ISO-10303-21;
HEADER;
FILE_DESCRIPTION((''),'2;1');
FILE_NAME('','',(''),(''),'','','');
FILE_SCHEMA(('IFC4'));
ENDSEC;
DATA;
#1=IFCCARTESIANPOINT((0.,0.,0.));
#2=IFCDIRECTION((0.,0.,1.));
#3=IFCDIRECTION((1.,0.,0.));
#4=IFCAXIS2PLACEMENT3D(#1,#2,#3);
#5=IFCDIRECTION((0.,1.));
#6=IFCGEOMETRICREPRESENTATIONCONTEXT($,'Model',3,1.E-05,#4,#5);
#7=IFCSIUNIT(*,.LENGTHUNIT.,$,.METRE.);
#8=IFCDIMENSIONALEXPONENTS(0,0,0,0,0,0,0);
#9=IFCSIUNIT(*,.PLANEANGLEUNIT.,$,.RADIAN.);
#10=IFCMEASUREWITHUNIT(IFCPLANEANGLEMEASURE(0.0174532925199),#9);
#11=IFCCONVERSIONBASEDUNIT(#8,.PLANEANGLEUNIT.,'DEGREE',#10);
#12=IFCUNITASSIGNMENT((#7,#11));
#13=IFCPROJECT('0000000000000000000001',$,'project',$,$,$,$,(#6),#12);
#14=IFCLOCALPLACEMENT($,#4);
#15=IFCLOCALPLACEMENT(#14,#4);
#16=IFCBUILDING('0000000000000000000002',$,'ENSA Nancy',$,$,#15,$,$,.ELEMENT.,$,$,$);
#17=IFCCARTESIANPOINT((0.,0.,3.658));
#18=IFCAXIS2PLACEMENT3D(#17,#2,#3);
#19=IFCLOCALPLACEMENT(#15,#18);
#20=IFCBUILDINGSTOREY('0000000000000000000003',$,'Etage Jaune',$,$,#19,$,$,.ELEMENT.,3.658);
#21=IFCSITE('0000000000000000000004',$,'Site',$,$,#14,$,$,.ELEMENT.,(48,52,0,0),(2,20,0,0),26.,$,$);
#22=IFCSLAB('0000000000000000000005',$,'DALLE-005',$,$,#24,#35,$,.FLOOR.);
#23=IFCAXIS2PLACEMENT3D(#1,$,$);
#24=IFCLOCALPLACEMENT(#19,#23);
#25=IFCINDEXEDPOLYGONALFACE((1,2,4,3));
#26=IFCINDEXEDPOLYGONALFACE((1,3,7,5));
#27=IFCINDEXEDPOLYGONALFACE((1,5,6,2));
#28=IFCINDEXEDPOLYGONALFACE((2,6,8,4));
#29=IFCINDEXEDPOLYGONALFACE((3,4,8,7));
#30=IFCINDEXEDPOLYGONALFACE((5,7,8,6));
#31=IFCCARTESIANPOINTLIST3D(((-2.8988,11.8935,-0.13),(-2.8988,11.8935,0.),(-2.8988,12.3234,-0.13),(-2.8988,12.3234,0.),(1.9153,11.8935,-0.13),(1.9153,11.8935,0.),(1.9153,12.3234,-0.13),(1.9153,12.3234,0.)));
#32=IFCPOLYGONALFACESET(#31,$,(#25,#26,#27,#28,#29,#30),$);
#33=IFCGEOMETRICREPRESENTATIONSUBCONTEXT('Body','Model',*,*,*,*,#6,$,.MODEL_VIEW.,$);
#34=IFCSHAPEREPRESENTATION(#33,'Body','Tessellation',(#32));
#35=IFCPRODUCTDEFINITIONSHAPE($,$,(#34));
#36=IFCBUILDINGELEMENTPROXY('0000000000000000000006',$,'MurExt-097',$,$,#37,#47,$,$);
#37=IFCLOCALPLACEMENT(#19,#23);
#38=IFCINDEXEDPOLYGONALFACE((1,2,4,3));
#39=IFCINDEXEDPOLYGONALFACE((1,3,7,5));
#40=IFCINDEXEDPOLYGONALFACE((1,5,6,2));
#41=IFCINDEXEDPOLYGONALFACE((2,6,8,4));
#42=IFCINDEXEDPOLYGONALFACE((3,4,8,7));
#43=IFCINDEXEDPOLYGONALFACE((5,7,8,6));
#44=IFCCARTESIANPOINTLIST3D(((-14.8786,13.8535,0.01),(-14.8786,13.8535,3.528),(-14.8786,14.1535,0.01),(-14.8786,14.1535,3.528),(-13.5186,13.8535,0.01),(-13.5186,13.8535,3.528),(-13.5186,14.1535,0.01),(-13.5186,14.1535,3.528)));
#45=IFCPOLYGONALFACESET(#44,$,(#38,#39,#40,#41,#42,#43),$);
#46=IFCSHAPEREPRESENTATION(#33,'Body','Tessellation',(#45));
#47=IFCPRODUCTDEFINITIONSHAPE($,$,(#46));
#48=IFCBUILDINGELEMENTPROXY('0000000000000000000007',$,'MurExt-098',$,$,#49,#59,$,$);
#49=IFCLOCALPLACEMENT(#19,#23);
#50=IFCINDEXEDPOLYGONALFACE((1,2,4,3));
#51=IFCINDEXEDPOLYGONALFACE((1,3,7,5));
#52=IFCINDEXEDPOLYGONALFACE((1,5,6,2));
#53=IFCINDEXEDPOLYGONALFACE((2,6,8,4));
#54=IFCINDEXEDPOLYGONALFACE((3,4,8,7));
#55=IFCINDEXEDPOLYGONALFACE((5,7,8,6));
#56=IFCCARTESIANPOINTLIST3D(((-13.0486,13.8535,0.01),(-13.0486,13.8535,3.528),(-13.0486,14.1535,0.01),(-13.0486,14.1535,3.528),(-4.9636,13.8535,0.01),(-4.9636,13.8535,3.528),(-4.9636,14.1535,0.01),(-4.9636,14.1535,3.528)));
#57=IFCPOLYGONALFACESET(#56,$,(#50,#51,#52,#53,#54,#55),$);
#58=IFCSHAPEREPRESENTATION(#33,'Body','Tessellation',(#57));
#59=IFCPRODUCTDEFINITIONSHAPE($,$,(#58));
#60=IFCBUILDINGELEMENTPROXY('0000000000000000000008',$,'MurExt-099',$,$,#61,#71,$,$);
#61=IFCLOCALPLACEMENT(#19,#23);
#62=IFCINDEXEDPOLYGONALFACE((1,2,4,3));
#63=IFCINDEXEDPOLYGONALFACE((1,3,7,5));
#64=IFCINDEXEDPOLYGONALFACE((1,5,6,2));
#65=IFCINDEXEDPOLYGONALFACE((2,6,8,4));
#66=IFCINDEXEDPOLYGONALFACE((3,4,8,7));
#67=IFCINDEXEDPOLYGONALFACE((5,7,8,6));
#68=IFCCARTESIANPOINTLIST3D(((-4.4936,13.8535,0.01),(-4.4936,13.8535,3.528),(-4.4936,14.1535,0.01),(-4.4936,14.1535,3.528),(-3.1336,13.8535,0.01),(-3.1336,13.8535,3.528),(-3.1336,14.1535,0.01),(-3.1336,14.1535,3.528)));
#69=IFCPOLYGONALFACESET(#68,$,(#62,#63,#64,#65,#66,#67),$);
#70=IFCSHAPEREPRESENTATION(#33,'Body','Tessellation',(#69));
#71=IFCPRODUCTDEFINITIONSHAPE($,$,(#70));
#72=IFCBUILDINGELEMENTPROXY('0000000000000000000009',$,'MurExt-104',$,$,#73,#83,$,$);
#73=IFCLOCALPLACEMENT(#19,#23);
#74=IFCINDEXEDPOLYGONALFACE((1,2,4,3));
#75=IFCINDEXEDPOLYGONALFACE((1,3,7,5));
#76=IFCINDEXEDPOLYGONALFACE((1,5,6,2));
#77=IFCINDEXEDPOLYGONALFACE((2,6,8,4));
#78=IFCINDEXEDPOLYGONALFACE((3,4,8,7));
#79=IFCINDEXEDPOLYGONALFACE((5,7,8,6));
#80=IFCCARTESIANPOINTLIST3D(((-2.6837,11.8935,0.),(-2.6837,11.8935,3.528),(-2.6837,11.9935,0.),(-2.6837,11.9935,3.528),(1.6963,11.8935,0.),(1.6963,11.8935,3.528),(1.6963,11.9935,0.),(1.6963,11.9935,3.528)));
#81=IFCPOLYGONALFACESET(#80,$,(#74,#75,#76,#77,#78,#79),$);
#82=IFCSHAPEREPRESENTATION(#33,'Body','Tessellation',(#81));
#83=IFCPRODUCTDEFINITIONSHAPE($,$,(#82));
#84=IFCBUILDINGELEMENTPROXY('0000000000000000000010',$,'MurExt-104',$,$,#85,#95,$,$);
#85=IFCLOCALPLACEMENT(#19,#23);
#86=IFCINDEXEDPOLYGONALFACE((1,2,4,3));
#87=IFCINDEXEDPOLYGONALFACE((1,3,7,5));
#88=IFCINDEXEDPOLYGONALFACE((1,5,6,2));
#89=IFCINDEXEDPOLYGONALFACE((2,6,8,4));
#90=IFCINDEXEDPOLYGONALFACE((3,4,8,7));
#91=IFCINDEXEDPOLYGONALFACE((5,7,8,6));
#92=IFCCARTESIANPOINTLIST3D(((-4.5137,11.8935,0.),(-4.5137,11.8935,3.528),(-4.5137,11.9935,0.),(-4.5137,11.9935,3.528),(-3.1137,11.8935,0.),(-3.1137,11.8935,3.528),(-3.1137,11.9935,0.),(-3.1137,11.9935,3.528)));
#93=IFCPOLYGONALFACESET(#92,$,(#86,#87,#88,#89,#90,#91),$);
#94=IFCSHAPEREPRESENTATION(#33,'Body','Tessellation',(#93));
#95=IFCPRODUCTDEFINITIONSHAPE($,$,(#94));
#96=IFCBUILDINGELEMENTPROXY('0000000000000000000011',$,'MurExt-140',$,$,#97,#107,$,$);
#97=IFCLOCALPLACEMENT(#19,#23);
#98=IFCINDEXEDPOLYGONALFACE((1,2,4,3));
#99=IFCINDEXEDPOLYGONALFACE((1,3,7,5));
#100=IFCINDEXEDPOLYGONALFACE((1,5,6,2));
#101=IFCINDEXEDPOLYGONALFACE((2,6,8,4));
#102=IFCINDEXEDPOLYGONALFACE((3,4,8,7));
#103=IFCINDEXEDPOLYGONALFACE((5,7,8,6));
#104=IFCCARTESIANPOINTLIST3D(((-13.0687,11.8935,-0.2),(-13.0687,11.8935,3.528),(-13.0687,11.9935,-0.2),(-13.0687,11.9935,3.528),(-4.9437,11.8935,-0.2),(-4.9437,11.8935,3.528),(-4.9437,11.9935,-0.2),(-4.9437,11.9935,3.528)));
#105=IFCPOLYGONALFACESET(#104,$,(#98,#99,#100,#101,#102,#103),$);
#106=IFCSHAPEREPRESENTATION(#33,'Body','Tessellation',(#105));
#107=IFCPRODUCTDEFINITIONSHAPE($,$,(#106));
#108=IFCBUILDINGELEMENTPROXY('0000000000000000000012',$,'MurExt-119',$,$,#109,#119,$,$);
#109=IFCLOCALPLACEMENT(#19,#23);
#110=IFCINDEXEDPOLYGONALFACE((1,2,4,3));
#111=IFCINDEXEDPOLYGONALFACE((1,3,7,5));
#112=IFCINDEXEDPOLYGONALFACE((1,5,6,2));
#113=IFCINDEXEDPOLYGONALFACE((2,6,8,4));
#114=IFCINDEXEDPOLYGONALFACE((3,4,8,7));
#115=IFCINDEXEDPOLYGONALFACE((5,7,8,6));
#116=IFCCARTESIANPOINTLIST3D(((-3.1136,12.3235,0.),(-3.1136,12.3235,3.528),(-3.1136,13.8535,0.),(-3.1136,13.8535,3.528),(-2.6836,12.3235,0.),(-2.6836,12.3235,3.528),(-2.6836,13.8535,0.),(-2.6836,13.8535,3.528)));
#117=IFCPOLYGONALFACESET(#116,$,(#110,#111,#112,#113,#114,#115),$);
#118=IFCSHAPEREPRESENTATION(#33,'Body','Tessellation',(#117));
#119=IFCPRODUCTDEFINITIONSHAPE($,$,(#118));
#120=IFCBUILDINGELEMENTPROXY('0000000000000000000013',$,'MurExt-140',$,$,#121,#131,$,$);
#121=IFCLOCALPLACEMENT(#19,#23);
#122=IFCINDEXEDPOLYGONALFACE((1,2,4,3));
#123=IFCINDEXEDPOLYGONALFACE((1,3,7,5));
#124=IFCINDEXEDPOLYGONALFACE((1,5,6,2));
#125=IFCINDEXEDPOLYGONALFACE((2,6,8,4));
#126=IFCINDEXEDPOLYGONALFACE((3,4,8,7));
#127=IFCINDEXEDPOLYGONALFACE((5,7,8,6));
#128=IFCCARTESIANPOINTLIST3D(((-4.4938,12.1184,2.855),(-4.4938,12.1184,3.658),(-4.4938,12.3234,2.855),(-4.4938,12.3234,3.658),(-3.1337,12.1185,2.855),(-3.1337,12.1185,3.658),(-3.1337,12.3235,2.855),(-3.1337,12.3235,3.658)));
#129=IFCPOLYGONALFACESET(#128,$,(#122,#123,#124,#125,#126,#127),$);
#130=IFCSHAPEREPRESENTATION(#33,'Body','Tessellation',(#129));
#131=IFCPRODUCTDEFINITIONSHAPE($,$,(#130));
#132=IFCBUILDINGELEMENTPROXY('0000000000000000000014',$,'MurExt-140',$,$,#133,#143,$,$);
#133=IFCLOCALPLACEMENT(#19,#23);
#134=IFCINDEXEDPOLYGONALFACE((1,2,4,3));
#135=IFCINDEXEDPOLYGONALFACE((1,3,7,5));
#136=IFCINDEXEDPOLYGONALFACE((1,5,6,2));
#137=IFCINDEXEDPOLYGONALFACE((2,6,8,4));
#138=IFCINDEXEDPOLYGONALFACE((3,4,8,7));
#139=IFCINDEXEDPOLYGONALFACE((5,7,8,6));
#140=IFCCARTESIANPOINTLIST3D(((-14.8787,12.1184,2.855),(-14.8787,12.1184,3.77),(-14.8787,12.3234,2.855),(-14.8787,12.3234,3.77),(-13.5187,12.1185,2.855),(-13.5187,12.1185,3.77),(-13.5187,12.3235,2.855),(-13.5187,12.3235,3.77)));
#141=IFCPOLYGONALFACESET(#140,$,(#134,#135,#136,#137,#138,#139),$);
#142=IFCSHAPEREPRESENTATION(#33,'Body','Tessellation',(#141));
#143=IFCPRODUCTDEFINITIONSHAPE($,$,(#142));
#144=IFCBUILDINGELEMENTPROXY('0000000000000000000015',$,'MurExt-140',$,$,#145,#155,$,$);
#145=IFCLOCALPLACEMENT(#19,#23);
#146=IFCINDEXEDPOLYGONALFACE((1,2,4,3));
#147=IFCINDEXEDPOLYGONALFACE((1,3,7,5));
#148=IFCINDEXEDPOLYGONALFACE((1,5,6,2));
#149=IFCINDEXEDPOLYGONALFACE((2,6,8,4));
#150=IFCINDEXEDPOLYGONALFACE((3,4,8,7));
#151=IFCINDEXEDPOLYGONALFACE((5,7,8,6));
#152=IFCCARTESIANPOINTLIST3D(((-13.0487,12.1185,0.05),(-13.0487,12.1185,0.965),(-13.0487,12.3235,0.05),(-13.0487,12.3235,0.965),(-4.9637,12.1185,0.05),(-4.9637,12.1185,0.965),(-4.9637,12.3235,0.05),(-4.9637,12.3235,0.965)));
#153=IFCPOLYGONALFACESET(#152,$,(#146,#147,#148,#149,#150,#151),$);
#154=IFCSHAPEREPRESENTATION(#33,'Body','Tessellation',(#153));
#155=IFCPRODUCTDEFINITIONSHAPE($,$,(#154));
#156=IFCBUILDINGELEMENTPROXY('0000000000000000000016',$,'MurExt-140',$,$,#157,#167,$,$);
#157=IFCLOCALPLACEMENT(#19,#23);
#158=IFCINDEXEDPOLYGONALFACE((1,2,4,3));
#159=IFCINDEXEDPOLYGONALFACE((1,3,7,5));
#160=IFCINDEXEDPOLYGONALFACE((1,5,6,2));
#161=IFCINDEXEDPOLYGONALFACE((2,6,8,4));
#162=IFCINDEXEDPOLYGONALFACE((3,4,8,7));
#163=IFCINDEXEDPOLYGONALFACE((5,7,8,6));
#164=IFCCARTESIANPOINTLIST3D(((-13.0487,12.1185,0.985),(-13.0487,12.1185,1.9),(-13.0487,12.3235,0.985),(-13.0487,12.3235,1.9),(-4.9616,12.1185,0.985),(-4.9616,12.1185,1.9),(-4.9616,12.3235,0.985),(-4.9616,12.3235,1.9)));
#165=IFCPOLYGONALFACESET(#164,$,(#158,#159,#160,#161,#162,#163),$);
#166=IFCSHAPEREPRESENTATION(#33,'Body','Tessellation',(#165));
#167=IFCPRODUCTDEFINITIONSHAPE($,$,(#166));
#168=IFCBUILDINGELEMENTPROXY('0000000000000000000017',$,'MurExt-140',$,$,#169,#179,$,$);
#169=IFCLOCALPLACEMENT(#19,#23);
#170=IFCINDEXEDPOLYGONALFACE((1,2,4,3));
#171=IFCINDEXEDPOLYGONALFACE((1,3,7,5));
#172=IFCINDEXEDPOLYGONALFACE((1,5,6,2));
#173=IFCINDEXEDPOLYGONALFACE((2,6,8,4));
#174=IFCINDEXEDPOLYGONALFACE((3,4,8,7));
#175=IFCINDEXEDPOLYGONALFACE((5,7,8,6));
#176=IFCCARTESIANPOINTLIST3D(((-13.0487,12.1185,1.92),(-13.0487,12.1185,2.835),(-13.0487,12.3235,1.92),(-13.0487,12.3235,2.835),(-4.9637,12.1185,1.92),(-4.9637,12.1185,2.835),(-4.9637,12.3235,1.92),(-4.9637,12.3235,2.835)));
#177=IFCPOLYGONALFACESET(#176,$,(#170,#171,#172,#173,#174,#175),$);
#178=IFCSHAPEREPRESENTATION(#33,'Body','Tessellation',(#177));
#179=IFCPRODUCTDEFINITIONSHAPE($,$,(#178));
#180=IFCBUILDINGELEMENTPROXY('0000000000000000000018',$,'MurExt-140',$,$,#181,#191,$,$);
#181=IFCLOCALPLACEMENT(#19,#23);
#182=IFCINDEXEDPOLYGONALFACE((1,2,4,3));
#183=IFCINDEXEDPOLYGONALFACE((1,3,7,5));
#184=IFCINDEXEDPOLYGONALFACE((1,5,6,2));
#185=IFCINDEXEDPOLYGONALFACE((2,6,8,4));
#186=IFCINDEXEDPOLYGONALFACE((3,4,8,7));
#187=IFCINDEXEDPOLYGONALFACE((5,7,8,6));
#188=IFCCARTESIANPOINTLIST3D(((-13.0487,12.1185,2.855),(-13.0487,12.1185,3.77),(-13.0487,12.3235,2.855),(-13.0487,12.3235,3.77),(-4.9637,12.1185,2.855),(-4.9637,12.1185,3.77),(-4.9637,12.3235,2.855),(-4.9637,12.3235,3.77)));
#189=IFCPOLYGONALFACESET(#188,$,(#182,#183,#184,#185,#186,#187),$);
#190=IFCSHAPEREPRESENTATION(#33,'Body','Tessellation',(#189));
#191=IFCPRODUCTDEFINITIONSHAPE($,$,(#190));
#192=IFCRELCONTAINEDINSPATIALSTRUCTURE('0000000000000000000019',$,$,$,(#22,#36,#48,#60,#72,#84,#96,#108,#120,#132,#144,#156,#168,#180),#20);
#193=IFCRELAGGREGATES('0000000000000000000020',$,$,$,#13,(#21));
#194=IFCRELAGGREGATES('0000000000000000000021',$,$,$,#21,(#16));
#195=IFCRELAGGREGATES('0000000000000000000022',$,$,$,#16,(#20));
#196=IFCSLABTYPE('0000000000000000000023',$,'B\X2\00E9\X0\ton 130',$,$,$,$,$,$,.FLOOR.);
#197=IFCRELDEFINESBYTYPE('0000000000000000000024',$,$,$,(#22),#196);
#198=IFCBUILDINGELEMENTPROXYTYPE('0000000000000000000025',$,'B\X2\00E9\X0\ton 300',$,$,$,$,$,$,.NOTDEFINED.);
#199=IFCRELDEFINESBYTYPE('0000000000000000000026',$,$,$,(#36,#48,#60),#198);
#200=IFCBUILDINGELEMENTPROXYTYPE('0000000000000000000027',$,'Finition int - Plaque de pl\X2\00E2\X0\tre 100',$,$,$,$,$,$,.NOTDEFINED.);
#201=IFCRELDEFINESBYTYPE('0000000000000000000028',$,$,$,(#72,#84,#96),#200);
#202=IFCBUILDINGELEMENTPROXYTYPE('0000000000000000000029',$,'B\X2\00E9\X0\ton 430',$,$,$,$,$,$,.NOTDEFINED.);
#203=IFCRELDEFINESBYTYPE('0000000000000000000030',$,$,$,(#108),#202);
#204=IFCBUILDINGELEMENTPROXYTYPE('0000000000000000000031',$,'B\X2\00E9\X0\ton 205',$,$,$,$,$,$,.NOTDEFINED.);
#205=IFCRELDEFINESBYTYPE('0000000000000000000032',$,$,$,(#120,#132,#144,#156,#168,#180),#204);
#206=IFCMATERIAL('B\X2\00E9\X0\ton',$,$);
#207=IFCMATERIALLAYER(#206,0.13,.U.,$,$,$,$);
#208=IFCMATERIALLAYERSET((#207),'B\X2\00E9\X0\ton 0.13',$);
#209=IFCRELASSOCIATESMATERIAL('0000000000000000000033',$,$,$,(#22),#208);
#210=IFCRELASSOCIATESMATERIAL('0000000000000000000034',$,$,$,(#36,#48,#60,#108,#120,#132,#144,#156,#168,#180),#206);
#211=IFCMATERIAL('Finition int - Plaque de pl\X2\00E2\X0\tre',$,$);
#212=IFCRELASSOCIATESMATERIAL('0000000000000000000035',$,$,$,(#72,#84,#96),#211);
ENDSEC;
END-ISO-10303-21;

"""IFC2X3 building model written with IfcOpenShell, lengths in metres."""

from ifc_helpers import new_model, entity, si_unit, converted_unit, direction, frame, origin_with_axes, place, context, subcontext, project, spatial, polyline, outline, extrude, material, layer, layer_set, layer_usage, type_object, element, save


model = new_model("IFC2X3")

# Units and contexts
model_context = context("Model", 3, precision=1e-05, world=origin_with_axes(), true_north=direction((0.0, 1.0)))
body_context = subcontext(model_context, "Body", "Model", "MODEL_VIEW")
ifc_project = project(units=[si_unit("LENGTHUNIT", "METRE"), converted_unit("PLANEANGLEUNIT", "DEGREE", entity("IfcPlaneAngleMeasure", 0.0174532925199), si_unit("PLANEANGLEUNIT", "RADIAN"), dimensions=[0, 0, 0, 0, 0, 0, 0])], contexts=[model_context])

# Site, building, storey
site_placement = place(None, origin_with_axes())
site = spatial("IfcSite", under=ifc_project, at=site_placement, Name="Site", CompositionType="ELEMENT", RefLatitude=(48, 52, 0, 0), RefLongitude=(2, 20, 0, 0), RefElevation=26.0)
building_placement = place(site_placement, origin_with_axes())
building = spatial("IfcBuilding", under=site, at=building_placement, Name="ENSA Nancy", CompositionType="ELEMENT")
storey_placement = place(building_placement, frame((0.0, 0.0, 3.658), z_axis=(0.0, 0.0, 1.0), x_axis=(1.0, 0.0, 0.0)))
storey = spatial("IfcBuildingStorey", under=building, at=storey_placement, Name="Etage Jaune", CompositionType="ELEMENT", Elevation=3.658)

# Slab
ifc_material_1 = material(Name="Béton")
ifc_layer = layer(ifc_material_1, 0.13, ventilated="UNKNOWN")
ifc_layer_set = layer_set([ifc_layer], Name="Béton 0.13")
ifc_layer_usage = layer_usage(ifc_layer_set, "AXIS3", "NEGATIVE", 0.13)
slab_type = type_object("IfcSlabType", Name="Béton 130", PredefinedType="FLOOR")
slab_placement = place(storey_placement, frame((-2.8988, 12.3234, 0.0), z_axis=(0.0, 0.0, 1.0), x_axis=(1.0, 0.0, 0.0)))
element("IfcSlab", 1, at=slab_placement, inside=storey, type_object=slab_type, material=ifc_layer_usage, Name="DALLE-005", PredefinedType="FLOOR", context=body_context, shape_type="SweptSolid", body=[
    extrude(outline(polyline([(0.0, 0.0), (0.0, -0.43), (4.814, -0.43), (4.814, 0.0), (0.0, 0.0)])), frame((0.0, 0.0, -0.13), z_axis=(0.0, 0.0, 1.0), x_axis=(1.0, 0.0, 0.0)), (0.0, 0.0, 1.0), 0.13),
])

# Building element proxies
building_element_proxy_type_1 = type_object("IfcBuildingElementProxyType", Name="Béton 300", PredefinedType="NOTDEFINED")
proxy_1_placement = place(storey_placement, frame((-14.8786, 13.8535, 0.01), z_axis=(0.0, 0.0, 1.0), x_axis=(1.0, 0.0, 0.0)))
element("IfcBuildingElementProxy", 2, at=proxy_1_placement, inside=storey, type_object=building_element_proxy_type_1, material=ifc_material_1, Name="MurExt-097", context=body_context, shape_type="SweptSolid", body=[
    extrude(outline(polyline([(0.0, 0.0), (1.36, 0.0), (1.36, 0.3), (0.0, 0.3), (0.0, 0.0)])), origin_with_axes(), (0.0, 0.0, 1.0), 3.518),
])
proxy_2_placement = place(storey_placement, frame((-13.0486, 13.8535, 0.01), z_axis=(0.0, 0.0, 1.0), x_axis=(1.0, 0.0, 0.0)))
element("IfcBuildingElementProxy", 3, at=proxy_2_placement, inside=storey, type_object=building_element_proxy_type_1, material=ifc_material_1, Name="MurExt-098", context=body_context, shape_type="SweptSolid", body=[
    extrude(outline(polyline([(0.0, 0.0), (8.085, 0.0), (8.085, 0.3), (0.0, 0.3), (0.0, 0.0)])), origin_with_axes(), (0.0, 0.0, 1.0), 3.518),
])
proxy_3_placement = place(storey_placement, frame((-4.4936, 13.8535, 0.01), z_axis=(0.0, 0.0, 1.0), x_axis=(1.0, 0.0, 0.0)))
element("IfcBuildingElementProxy", 4, at=proxy_3_placement, inside=storey, type_object=building_element_proxy_type_1, material=ifc_material_1, Name="MurExt-099", context=body_context, shape_type="SweptSolid", body=[
    extrude(outline(polyline([(0.0, 0.0), (1.36, 0.0), (1.36, 0.3), (0.0, 0.3), (0.0, 0.0)])), origin_with_axes(), (0.0, 0.0, 1.0), 3.518),
])
ifc_material_2 = material(Name="Finition int - Plaque de plâtre")
building_element_proxy_type_2 = type_object("IfcBuildingElementProxyType", Name="Finition int - Plaque de plâtre 100", PredefinedType="NOTDEFINED")
proxy_4_placement = place(storey_placement, frame((-2.6837, 11.8935, 0.0), z_axis=(0.0, 0.0, 1.0), x_axis=(1.0, 0.0, 0.0)))
element("IfcBuildingElementProxy", 5, at=proxy_4_placement, inside=storey, type_object=building_element_proxy_type_2, material=ifc_material_2, Name="MurExt-104", context=body_context, shape_type="SweptSolid", body=[
    extrude(outline(polyline([(0.0, 0.0), (4.38, 0.0), (4.38, 0.1), (0.0, 0.1), (0.0, 0.0)])), origin_with_axes(), (0.0, 0.0, 1.0), 3.528),
])
proxy_5_placement = place(storey_placement, frame((-4.5137, 11.8935, 0.0), z_axis=(0.0, 0.0, 1.0), x_axis=(1.0, 0.000001, 0.0)))
element("IfcBuildingElementProxy", 6, at=proxy_5_placement, inside=storey, type_object=building_element_proxy_type_2, material=ifc_material_2, Name="MurExt-104", context=body_context, shape_type="SweptSolid", body=[
    extrude(outline(polyline([(0.0, 0.0), (1.4, 0.0), (1.4, 0.1), (0.0, 0.1), (0.0, 0.0)])), origin_with_axes(), (0.0, 0.0, 1.0), 3.528),
])
proxy_6_placement = place(storey_placement, frame((-13.0687, 11.8935, -0.2), z_axis=(0.0, 0.0, 1.0), x_axis=(1.0, 0.0, 0.0)))
element("IfcBuildingElementProxy", 7, at=proxy_6_placement, inside=storey, type_object=building_element_proxy_type_2, material=ifc_material_2, Name="MurExt-140", context=body_context, shape_type="SweptSolid", body=[
    extrude(outline(polyline([(0.0, 0.0), (8.125, 0.0), (8.125, 0.1), (0.0, 0.1), (0.0, 0.0)])), origin_with_axes(), (0.0, 0.0, 1.0), 3.728),
])
building_element_proxy_type_3 = type_object("IfcBuildingElementProxyType", Name="Béton 430", PredefinedType="NOTDEFINED")
proxy_7_placement = place(storey_placement, frame((-3.1136, 13.8535, 0.0), z_axis=(0.0, 0.0, 1.0), x_axis=(0.0, -1.0, 0.0)))
element("IfcBuildingElementProxy", 8, at=proxy_7_placement, inside=storey, type_object=building_element_proxy_type_3, material=ifc_material_1, Name="MurExt-119", context=body_context, shape_type="SweptSolid", body=[
    extrude(outline(polyline([(0.0, 0.0), (1.53, 0.0), (1.53, 0.43), (0.0, 0.43), (0.0, 0.0)])), origin_with_axes(), (0.0, 0.0, 1.0), 3.528),
])
building_element_proxy_type_4 = type_object("IfcBuildingElementProxyType", Name="Béton 205", PredefinedType="NOTDEFINED")
proxy_8_placement = place(storey_placement, frame((-4.4938, 12.3234, 2.855), z_axis=(0.0, 0.0, 1.0), x_axis=(1.0, 0.000034, 0.0)))
element("IfcBuildingElementProxy", 9, at=proxy_8_placement, inside=storey, type_object=building_element_proxy_type_4, material=ifc_material_1, Name="MurExt-140", context=body_context, shape_type="SweptSolid", body=[
    extrude(outline(polyline([(0.0, -0.205), (1.3601, -0.205), (1.3601, 0.0), (0.0, 0.0), (0.0, -0.205)])), origin_with_axes(), (0.0, 0.0, 1.0), 0.803),
])
proxy_9_placement = place(storey_placement, frame((-14.8787, 12.3234, 2.855), z_axis=(0.0, 0.0, 1.0), x_axis=(1.0, 0.000034, 0.0)))
element("IfcBuildingElementProxy", 10, at=proxy_9_placement, inside=storey, type_object=building_element_proxy_type_4, material=ifc_material_1, Name="MurExt-140", context=body_context, shape_type="SweptSolid", body=[
    extrude(outline(polyline([(0.0, -0.205), (1.3601, -0.205), (1.3601, 0.0), (0.0, 0.0), (0.0, -0.205)])), origin_with_axes(), (0.0, 0.0, 1.0), 0.915),
])
proxy_10_placement = place(storey_placement, frame((-13.0487, 12.3235, 0.05), z_axis=(0.0, 0.0, 1.0), x_axis=(1.0, 0.0, 0.0)))
element("IfcBuildingElementProxy", 11, at=proxy_10_placement, inside=storey, type_object=building_element_proxy_type_4, material=ifc_material_1, Name="MurExt-140", context=body_context, shape_type="SweptSolid", body=[
    extrude(outline(polyline([(0.0, -0.205), (8.085, -0.205), (8.085, 0.0), (0.0, 0.0), (0.0, -0.205)])), origin_with_axes(), (0.0, 0.0, 1.0), 0.915),
])
proxy_11_placement = place(storey_placement, frame((-13.0487, 12.3235, 0.985), z_axis=(0.0, 0.0, 1.0), x_axis=(1.0, 0.0, 0.0)))
element("IfcBuildingElementProxy", 12, at=proxy_11_placement, inside=storey, type_object=building_element_proxy_type_4, material=ifc_material_1, Name="MurExt-140", context=body_context, shape_type="SweptSolid", body=[
    extrude(outline(polyline([(0.0, -0.205), (8.087, -0.205), (8.087, 0.0), (0.0, 0.0), (0.0, -0.205)])), origin_with_axes(), (0.0, 0.0, 1.0), 0.915),
])
for number, where, z_axis, x_axis, name in (
    (13, (-13.0487, 12.3235, 1.92), (0.0, 0.0, 1.0), (1.0, 0.0, 0.0), "MurExt-140"),
    (14, (-13.0487, 12.3235, 2.855), (0.0, 0.0, 1.0), (1.0, 0.0, 0.0), "MurExt-140"),
):
    element("IfcBuildingElementProxy", number, at=place(storey_placement, frame(where, z_axis=z_axis, x_axis=x_axis)), inside=storey, type_object=building_element_proxy_type_4, material=ifc_material_1, Name=name, context=body_context, shape_type="SweptSolid", body=[
        extrude(outline(polyline([(0.0, -0.205), (8.085, -0.205), (8.085, 0.0), (0.0, 0.0), (0.0, -0.205)])), origin_with_axes(), (0.0, 0.0, 1.0), 0.915),
    ])

save(model, "model.ifc")
